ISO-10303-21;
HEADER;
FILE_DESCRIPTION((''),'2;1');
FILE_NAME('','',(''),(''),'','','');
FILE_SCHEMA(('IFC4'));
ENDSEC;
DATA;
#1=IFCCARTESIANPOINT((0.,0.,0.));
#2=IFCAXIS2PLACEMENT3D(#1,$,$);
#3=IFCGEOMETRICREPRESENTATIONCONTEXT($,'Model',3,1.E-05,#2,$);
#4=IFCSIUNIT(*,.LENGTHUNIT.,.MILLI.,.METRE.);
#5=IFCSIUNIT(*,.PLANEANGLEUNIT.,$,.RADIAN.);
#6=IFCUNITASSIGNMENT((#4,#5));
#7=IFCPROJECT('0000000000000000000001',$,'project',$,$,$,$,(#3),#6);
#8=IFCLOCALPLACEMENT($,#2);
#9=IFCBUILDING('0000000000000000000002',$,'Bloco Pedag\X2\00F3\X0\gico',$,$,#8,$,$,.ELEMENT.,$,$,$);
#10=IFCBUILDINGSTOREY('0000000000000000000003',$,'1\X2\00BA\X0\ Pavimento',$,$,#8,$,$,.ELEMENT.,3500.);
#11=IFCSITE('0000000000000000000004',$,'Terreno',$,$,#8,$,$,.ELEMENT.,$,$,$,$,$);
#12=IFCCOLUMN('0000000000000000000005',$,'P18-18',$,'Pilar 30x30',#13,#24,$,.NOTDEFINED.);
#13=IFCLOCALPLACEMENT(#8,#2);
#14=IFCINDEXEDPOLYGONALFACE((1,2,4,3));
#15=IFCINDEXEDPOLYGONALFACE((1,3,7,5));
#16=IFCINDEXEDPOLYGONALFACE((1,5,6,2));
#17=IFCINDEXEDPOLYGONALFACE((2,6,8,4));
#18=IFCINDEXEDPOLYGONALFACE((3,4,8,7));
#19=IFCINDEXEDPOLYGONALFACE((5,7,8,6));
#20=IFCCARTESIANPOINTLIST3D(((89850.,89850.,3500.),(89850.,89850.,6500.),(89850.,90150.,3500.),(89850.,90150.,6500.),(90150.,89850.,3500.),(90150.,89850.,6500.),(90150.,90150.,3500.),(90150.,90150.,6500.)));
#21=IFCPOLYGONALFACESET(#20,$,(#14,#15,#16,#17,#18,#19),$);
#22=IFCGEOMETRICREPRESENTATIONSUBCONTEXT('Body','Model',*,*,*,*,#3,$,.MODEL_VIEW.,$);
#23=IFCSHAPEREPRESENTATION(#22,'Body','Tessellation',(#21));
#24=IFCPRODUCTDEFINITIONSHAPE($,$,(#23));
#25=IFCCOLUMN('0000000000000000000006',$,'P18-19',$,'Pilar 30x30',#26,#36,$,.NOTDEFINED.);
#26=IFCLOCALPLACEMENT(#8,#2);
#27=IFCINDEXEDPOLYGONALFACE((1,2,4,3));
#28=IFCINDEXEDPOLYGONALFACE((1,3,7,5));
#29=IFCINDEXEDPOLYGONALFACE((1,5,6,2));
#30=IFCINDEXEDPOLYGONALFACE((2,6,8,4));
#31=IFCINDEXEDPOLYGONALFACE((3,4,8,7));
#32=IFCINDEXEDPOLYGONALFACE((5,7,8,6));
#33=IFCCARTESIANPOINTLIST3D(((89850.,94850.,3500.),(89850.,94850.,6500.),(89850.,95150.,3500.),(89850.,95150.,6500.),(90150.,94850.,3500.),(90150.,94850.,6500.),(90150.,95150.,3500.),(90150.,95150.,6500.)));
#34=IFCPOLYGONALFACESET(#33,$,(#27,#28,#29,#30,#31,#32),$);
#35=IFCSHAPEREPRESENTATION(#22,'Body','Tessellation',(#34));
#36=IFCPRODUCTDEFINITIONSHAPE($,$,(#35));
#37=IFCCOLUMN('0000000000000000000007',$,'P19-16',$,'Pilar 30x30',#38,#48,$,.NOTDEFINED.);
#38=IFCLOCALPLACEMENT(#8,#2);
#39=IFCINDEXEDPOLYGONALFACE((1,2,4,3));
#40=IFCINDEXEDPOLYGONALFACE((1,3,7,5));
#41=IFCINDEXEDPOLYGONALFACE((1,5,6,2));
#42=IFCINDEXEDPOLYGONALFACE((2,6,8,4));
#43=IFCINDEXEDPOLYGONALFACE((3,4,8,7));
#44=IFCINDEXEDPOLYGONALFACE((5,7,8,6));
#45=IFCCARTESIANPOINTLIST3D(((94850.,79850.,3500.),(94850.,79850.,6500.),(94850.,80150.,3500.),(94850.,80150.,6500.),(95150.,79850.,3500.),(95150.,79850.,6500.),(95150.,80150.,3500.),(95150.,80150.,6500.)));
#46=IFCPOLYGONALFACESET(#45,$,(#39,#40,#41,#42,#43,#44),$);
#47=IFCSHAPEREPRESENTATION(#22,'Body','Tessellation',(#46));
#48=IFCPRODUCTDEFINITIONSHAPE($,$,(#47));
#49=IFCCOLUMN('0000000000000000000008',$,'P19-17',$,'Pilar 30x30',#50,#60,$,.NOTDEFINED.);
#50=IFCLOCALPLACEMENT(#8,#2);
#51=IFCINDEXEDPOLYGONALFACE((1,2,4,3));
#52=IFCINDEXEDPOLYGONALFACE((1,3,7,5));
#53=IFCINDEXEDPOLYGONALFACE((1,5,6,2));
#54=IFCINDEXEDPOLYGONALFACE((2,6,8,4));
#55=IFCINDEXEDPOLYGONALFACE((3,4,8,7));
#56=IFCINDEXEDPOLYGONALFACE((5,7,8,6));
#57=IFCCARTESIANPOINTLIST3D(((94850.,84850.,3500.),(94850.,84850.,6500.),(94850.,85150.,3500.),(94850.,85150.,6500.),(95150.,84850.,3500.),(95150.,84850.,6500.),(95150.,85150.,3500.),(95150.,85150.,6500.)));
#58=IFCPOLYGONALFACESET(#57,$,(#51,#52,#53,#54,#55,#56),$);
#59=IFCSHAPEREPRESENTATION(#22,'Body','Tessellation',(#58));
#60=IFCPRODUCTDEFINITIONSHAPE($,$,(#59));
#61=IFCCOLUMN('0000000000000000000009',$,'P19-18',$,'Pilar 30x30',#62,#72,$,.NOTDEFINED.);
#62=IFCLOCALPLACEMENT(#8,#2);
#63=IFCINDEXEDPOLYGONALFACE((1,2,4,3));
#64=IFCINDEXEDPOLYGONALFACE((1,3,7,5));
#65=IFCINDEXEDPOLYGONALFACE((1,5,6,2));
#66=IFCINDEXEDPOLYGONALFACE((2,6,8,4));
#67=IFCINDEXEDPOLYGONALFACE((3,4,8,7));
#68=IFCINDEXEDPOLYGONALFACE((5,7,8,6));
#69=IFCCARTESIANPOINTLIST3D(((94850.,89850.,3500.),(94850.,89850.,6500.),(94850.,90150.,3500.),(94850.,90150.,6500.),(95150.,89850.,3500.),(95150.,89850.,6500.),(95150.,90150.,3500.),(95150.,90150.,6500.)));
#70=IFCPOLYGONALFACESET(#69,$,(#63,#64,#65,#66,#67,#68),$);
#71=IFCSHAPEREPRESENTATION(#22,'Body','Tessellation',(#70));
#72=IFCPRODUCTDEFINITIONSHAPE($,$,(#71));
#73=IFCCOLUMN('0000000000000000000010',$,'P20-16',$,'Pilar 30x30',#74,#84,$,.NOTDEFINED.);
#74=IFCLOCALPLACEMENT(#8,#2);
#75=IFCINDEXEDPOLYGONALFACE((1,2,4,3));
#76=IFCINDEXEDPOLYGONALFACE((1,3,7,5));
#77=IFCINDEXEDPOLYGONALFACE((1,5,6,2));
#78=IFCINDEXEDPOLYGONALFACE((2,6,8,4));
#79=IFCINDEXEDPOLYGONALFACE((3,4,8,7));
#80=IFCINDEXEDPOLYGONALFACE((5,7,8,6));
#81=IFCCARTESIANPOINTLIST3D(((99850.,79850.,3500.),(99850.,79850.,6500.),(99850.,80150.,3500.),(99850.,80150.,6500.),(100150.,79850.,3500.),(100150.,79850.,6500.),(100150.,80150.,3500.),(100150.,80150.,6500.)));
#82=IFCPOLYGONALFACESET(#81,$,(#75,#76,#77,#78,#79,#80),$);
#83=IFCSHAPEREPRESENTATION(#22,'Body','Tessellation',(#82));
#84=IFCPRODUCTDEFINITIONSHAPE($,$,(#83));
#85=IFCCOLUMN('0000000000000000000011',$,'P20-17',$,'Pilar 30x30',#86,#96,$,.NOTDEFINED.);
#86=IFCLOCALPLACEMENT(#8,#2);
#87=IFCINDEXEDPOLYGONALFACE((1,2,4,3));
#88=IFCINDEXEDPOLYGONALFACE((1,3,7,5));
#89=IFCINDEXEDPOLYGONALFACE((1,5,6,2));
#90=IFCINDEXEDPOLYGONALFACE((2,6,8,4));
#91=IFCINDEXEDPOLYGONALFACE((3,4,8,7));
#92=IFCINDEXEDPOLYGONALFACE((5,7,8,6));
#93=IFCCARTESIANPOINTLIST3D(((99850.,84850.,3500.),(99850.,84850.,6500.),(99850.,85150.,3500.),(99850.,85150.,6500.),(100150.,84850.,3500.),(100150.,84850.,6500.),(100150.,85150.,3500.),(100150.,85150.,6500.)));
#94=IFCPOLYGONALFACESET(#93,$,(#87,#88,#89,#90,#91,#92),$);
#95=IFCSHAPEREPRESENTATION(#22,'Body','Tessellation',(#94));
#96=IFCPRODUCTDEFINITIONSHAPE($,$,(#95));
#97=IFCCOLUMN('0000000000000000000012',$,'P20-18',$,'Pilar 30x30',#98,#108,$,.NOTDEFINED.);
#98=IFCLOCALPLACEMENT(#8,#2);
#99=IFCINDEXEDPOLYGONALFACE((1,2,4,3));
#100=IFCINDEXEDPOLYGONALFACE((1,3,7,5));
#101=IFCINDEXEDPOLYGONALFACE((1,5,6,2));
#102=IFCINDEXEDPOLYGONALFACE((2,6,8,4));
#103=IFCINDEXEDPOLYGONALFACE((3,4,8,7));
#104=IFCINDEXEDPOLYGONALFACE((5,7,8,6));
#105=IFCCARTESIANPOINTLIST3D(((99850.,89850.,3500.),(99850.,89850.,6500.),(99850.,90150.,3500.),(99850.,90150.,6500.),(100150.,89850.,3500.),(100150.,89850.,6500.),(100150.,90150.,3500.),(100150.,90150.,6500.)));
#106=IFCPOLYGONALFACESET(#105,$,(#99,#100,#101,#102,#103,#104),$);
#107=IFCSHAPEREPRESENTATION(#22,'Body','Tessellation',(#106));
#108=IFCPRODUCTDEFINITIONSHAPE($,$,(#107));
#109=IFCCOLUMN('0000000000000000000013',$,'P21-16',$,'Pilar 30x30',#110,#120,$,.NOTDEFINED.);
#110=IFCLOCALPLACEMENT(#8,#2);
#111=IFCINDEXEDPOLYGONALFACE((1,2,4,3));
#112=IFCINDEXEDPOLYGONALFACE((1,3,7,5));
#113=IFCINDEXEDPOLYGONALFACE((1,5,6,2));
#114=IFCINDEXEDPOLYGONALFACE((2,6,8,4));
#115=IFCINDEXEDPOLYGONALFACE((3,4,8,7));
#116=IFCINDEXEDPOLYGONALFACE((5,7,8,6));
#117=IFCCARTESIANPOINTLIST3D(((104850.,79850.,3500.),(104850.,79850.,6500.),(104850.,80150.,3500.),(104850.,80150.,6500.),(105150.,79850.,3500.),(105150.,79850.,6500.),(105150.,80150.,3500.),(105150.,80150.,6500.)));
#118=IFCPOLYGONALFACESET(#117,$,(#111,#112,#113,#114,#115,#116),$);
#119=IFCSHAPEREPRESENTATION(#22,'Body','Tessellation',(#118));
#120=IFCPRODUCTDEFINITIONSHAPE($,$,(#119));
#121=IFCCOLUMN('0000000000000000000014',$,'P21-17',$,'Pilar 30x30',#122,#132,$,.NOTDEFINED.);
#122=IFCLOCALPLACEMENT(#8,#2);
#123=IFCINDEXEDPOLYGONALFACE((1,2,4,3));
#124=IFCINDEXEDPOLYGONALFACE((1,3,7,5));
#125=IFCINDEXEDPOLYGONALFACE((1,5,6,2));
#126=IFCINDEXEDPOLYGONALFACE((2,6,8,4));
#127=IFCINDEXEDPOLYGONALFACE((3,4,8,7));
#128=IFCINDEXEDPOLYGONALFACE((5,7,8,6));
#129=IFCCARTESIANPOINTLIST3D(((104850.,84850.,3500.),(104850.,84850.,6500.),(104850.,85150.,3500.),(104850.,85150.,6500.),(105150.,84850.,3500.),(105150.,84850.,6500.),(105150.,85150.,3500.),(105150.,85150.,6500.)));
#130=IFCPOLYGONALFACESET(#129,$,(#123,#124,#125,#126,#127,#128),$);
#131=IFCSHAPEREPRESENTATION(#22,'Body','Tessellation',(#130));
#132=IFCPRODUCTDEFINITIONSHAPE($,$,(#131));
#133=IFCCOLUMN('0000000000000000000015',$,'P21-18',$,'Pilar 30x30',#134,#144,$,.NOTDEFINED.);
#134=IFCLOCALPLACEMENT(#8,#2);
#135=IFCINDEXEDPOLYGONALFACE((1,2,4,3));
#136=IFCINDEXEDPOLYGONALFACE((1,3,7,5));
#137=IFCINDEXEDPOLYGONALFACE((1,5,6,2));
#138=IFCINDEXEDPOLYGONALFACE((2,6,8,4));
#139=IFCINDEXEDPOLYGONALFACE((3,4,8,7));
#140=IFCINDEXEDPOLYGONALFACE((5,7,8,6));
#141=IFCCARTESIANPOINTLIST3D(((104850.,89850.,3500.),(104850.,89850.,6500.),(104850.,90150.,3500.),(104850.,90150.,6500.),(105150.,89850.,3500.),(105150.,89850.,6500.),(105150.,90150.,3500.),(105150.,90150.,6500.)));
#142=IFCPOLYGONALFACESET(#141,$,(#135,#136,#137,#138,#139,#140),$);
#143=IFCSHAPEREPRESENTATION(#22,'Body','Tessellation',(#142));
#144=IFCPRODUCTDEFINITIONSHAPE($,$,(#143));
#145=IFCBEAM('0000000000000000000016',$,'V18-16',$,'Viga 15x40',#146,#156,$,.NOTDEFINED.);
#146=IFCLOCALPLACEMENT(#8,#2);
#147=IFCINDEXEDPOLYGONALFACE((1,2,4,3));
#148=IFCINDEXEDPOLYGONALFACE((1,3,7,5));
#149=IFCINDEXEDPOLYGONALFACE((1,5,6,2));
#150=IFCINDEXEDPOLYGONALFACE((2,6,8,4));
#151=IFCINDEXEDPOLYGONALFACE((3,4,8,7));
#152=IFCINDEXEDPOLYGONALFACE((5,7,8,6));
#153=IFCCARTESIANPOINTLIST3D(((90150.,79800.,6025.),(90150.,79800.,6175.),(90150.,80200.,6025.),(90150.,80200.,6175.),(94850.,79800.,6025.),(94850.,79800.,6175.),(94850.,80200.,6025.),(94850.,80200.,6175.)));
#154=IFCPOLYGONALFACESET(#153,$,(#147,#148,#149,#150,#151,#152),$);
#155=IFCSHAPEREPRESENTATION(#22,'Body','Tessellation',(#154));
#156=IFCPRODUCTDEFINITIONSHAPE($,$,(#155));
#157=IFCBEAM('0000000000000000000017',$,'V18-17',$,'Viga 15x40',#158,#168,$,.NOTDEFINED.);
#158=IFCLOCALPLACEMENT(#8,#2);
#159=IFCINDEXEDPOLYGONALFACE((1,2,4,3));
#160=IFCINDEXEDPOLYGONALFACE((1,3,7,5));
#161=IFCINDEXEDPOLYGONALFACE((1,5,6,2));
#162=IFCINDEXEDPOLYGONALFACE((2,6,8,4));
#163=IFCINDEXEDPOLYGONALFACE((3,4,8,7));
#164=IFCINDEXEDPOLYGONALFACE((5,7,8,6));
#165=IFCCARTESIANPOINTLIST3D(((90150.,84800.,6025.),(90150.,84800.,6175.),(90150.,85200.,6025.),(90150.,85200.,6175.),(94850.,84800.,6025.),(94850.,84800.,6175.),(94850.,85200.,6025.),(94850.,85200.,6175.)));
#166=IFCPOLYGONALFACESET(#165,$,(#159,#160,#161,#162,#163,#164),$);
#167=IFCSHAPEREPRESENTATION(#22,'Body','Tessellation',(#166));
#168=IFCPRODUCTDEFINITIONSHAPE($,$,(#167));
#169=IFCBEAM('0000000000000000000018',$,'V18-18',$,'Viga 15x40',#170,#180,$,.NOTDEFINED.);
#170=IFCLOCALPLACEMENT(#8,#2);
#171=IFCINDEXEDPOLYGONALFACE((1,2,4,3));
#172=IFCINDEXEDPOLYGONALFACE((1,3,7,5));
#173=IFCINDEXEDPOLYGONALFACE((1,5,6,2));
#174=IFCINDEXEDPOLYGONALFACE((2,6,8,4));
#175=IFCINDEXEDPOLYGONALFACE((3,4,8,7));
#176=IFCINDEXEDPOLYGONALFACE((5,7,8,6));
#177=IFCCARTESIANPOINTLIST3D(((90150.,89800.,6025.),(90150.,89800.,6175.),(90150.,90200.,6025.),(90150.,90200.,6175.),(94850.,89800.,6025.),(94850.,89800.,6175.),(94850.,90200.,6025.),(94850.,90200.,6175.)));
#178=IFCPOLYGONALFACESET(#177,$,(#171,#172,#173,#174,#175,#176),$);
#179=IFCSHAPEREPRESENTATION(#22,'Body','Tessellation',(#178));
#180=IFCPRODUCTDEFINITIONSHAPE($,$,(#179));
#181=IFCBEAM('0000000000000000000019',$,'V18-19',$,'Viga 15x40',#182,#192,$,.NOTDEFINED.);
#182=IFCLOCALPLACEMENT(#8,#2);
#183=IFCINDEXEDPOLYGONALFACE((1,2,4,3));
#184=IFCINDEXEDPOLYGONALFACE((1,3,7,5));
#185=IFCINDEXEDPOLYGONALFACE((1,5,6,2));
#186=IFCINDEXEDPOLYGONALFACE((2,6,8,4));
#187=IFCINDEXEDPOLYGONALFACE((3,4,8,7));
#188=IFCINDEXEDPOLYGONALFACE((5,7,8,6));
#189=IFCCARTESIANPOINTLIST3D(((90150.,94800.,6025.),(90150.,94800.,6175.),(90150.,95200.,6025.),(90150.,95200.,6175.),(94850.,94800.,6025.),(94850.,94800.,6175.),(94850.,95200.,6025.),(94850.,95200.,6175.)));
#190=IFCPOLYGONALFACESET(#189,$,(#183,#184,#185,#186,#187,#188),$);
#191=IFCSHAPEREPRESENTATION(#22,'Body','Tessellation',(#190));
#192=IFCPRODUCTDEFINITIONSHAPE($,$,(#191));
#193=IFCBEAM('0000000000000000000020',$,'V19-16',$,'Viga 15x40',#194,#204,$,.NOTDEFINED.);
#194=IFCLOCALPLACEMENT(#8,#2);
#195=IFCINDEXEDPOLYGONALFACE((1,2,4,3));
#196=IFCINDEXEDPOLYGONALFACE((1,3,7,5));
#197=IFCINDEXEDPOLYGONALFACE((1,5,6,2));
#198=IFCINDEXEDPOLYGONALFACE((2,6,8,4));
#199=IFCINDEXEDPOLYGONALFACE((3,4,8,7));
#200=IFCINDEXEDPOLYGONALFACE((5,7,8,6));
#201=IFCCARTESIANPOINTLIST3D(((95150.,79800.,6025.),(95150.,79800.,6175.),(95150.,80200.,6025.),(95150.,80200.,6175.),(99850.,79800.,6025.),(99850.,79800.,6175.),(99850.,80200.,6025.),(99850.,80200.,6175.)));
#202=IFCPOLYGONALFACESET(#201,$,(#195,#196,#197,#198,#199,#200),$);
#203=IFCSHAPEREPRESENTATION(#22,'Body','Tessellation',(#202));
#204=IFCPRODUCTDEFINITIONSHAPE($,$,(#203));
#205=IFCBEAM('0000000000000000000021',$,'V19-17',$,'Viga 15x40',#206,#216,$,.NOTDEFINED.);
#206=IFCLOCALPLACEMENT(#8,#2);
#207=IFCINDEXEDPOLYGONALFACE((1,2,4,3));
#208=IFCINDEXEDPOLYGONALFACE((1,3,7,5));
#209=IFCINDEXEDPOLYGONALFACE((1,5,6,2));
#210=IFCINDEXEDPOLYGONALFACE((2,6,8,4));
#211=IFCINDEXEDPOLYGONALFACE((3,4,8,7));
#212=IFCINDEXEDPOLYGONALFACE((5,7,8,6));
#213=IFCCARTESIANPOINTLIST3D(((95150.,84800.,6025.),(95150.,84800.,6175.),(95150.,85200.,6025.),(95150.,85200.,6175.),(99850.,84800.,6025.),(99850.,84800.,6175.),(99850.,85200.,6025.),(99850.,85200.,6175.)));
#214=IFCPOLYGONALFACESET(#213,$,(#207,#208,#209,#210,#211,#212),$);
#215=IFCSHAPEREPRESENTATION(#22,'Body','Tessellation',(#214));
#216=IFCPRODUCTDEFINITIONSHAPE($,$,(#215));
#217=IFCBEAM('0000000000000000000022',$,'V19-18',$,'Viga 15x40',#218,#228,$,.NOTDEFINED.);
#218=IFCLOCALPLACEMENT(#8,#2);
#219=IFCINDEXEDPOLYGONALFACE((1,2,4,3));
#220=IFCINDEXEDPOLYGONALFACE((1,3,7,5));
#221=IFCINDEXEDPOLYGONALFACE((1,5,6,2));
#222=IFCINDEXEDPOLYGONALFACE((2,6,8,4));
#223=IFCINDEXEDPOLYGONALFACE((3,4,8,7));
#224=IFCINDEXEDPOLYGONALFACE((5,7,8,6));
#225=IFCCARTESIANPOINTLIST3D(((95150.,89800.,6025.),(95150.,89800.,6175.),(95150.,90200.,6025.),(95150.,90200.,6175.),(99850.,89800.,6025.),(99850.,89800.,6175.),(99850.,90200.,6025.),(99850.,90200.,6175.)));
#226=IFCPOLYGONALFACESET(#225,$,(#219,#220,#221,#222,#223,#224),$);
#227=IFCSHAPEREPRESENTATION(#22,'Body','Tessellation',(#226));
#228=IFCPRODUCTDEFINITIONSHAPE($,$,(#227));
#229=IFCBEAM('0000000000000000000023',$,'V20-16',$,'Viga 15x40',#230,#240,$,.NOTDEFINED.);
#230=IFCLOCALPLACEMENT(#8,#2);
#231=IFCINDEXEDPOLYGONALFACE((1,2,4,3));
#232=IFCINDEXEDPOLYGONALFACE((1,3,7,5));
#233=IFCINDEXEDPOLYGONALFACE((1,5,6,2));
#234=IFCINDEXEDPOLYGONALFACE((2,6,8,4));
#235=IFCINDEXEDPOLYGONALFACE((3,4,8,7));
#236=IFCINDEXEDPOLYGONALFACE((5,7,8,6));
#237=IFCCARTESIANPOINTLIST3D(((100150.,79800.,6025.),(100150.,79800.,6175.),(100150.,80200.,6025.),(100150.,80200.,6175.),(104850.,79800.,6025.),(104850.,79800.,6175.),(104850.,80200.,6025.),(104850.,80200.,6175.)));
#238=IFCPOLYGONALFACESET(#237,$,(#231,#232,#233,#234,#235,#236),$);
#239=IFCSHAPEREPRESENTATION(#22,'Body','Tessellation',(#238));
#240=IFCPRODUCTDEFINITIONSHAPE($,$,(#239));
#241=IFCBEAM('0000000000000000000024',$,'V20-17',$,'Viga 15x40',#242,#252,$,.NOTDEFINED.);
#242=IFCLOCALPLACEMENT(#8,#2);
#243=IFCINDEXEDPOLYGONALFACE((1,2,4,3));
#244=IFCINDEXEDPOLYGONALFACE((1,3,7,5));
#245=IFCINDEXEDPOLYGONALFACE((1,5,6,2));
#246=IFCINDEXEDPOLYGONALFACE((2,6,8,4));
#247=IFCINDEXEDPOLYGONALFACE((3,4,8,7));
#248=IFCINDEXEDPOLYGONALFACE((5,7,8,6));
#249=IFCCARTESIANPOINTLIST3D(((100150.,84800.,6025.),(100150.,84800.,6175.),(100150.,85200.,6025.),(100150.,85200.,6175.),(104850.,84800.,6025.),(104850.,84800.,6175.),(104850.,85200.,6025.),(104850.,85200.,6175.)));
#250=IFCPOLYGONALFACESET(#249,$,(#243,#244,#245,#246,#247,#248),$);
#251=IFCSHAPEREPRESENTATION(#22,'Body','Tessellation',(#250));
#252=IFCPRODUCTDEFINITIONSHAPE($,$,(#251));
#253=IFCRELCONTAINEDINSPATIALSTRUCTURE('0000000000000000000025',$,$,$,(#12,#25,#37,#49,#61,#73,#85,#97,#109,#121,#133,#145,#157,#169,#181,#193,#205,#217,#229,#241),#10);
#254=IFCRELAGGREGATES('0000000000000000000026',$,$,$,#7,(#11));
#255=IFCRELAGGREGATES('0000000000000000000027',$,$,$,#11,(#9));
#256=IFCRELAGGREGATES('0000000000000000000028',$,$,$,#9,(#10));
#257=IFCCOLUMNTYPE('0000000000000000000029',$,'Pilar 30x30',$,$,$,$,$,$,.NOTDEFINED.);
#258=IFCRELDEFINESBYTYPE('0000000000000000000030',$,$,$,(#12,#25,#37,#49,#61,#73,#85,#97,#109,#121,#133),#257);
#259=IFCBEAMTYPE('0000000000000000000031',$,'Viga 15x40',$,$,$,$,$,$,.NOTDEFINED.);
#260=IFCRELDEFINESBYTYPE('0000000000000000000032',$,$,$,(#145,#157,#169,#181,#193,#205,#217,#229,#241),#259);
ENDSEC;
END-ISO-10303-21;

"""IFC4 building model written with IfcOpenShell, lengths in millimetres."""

from ifc_helpers import new_model, si_unit, frame, origin, origin_2d, place, context, subcontext, project, spatial, rectangle, extrude, type_object, element, save


model = new_model("IFC4")

# Units and contexts
model_context = context("Model", 3, precision=1e-05, world=origin())
body_context = subcontext(model_context, "Body", "Model", "MODEL_VIEW")
ifc_project = project(units=[si_unit("LENGTHUNIT", "METRE", prefix="MILLI"), si_unit("PLANEANGLEUNIT", "RADIAN")], contexts=[model_context])

# Site, building, storey
placement = place(None, origin())
site = spatial("IfcSite", under=ifc_project, at=placement, Name="Terreno", CompositionType="ELEMENT")
building = spatial("IfcBuilding", under=site, at=placement, Name="Bloco Pedagógico", CompositionType="ELEMENT")
storey = spatial("IfcBuildingStorey", under=building, at=placement, Name="1º Pavimento", CompositionType="ELEMENT", Elevation=3500.0)

# Columns
column_type = type_object("IfcColumnType", Name="Pilar 30x30", PredefinedType="NOTDEFINED")
for number, where, z_axis, x_axis, name in (
    (1, (90000.0, 90000.0, 3500.0), (0.0, 0.0, 1.0), (1.0, 0.0, 0.0), "P18-18"),
    (2, (90000.0, 95000.0, 3500.0), (0.0, 0.0, 1.0), (1.0, 0.0, 0.0), "P18-19"),
    (3, (95000.0, 80000.0, 3500.0), (0.0, 0.0, 1.0), (1.0, 0.0, 0.0), "P19-16"),
    (4, (95000.0, 85000.0, 3500.0), (0.0, 0.0, 1.0), (1.0, 0.0, 0.0), "P19-17"),
    (5, (95000.0, 90000.0, 3500.0), (0.0, 0.0, 1.0), (1.0, 0.0, 0.0), "P19-18"),
    (6, (100000.0, 80000.0, 3500.0), (0.0, 0.0, 1.0), (1.0, 0.0, 0.0), "P20-16"),
    (7, (100000.0, 85000.0, 3500.0), (0.0, 0.0, 1.0), (1.0, 0.0, 0.0), "P20-17"),
    (8, (100000.0, 90000.0, 3500.0), (0.0, 0.0, 1.0), (1.0, 0.0, 0.0), "P20-18"),
    (9, (105000.0, 80000.0, 3500.0), (0.0, 0.0, 1.0), (1.0, 0.0, 0.0), "P21-16"),
    (10, (105000.0, 85000.0, 3500.0), (0.0, 0.0, 1.0), (1.0, 0.0, 0.0), "P21-17"),
    (11, (105000.0, 90000.0, 3500.0), (0.0, 0.0, 1.0), (1.0, 0.0, 0.0), "P21-18"),
):
    element("IfcColumn", number, at=place(None, frame(where, z_axis=z_axis, x_axis=x_axis)), inside=storey, type_object=column_type, Name=name, ObjectType="Pilar 30x30", PredefinedType="NOTDEFINED", context=body_context, shape_type="SweptSolid", body=[
        extrude(rectangle(XDim=300.0, YDim=300.0, at=origin_2d()), None, (0.0, 0.0, 1.0), 3000.0),
    ])

# Beams
beam_type = type_object("IfcBeamType", Name="Viga 15x40", PredefinedType="NOTDEFINED")
for number, where, z_axis, x_axis, name in (
    (12, (90150.0, 80000.0, 6100.0), (1.0, 0.0, 0.0), (0.0, 1.0, 0.0), "V18-16"),
    (13, (90150.0, 85000.0, 6100.0), (1.0, 0.0, 0.0), (0.0, 1.0, 0.0), "V18-17"),
    (14, (90150.0, 90000.0, 6100.0), (1.0, 0.0, 0.0), (0.0, 1.0, 0.0), "V18-18"),
    (15, (90150.0, 95000.0, 6100.0), (1.0, 0.0, 0.0), (0.0, 1.0, 0.0), "V18-19"),
    (16, (95150.0, 80000.0, 6100.0), (1.0, 0.0, 0.0), (0.0, 1.0, 0.0), "V19-16"),
    (17, (95150.0, 85000.0, 6100.0), (1.0, 0.0, 0.0), (0.0, 1.0, 0.0), "V19-17"),
    (18, (95150.0, 90000.0, 6100.0), (1.0, 0.0, 0.0), (0.0, 1.0, 0.0), "V19-18"),
    (19, (100150.0, 80000.0, 6100.0), (1.0, 0.0, 0.0), (0.0, 1.0, 0.0), "V20-16"),
    (20, (100150.0, 85000.0, 6100.0), (1.0, 0.0, 0.0), (0.0, 1.0, 0.0), "V20-17"),
):
    element("IfcBeam", number, at=place(None, frame(where, z_axis=z_axis, x_axis=x_axis)), inside=storey, type_object=beam_type, Name=name, ObjectType="Viga 15x40", PredefinedType="NOTDEFINED", context=body_context, shape_type="SweptSolid", body=[
        extrude(rectangle(XDim=400.0, YDim=150.0, at=origin_2d()), None, (0.0, 0.0, 1.0), 4700.0),
    ])

save(model, "model.ifc")
